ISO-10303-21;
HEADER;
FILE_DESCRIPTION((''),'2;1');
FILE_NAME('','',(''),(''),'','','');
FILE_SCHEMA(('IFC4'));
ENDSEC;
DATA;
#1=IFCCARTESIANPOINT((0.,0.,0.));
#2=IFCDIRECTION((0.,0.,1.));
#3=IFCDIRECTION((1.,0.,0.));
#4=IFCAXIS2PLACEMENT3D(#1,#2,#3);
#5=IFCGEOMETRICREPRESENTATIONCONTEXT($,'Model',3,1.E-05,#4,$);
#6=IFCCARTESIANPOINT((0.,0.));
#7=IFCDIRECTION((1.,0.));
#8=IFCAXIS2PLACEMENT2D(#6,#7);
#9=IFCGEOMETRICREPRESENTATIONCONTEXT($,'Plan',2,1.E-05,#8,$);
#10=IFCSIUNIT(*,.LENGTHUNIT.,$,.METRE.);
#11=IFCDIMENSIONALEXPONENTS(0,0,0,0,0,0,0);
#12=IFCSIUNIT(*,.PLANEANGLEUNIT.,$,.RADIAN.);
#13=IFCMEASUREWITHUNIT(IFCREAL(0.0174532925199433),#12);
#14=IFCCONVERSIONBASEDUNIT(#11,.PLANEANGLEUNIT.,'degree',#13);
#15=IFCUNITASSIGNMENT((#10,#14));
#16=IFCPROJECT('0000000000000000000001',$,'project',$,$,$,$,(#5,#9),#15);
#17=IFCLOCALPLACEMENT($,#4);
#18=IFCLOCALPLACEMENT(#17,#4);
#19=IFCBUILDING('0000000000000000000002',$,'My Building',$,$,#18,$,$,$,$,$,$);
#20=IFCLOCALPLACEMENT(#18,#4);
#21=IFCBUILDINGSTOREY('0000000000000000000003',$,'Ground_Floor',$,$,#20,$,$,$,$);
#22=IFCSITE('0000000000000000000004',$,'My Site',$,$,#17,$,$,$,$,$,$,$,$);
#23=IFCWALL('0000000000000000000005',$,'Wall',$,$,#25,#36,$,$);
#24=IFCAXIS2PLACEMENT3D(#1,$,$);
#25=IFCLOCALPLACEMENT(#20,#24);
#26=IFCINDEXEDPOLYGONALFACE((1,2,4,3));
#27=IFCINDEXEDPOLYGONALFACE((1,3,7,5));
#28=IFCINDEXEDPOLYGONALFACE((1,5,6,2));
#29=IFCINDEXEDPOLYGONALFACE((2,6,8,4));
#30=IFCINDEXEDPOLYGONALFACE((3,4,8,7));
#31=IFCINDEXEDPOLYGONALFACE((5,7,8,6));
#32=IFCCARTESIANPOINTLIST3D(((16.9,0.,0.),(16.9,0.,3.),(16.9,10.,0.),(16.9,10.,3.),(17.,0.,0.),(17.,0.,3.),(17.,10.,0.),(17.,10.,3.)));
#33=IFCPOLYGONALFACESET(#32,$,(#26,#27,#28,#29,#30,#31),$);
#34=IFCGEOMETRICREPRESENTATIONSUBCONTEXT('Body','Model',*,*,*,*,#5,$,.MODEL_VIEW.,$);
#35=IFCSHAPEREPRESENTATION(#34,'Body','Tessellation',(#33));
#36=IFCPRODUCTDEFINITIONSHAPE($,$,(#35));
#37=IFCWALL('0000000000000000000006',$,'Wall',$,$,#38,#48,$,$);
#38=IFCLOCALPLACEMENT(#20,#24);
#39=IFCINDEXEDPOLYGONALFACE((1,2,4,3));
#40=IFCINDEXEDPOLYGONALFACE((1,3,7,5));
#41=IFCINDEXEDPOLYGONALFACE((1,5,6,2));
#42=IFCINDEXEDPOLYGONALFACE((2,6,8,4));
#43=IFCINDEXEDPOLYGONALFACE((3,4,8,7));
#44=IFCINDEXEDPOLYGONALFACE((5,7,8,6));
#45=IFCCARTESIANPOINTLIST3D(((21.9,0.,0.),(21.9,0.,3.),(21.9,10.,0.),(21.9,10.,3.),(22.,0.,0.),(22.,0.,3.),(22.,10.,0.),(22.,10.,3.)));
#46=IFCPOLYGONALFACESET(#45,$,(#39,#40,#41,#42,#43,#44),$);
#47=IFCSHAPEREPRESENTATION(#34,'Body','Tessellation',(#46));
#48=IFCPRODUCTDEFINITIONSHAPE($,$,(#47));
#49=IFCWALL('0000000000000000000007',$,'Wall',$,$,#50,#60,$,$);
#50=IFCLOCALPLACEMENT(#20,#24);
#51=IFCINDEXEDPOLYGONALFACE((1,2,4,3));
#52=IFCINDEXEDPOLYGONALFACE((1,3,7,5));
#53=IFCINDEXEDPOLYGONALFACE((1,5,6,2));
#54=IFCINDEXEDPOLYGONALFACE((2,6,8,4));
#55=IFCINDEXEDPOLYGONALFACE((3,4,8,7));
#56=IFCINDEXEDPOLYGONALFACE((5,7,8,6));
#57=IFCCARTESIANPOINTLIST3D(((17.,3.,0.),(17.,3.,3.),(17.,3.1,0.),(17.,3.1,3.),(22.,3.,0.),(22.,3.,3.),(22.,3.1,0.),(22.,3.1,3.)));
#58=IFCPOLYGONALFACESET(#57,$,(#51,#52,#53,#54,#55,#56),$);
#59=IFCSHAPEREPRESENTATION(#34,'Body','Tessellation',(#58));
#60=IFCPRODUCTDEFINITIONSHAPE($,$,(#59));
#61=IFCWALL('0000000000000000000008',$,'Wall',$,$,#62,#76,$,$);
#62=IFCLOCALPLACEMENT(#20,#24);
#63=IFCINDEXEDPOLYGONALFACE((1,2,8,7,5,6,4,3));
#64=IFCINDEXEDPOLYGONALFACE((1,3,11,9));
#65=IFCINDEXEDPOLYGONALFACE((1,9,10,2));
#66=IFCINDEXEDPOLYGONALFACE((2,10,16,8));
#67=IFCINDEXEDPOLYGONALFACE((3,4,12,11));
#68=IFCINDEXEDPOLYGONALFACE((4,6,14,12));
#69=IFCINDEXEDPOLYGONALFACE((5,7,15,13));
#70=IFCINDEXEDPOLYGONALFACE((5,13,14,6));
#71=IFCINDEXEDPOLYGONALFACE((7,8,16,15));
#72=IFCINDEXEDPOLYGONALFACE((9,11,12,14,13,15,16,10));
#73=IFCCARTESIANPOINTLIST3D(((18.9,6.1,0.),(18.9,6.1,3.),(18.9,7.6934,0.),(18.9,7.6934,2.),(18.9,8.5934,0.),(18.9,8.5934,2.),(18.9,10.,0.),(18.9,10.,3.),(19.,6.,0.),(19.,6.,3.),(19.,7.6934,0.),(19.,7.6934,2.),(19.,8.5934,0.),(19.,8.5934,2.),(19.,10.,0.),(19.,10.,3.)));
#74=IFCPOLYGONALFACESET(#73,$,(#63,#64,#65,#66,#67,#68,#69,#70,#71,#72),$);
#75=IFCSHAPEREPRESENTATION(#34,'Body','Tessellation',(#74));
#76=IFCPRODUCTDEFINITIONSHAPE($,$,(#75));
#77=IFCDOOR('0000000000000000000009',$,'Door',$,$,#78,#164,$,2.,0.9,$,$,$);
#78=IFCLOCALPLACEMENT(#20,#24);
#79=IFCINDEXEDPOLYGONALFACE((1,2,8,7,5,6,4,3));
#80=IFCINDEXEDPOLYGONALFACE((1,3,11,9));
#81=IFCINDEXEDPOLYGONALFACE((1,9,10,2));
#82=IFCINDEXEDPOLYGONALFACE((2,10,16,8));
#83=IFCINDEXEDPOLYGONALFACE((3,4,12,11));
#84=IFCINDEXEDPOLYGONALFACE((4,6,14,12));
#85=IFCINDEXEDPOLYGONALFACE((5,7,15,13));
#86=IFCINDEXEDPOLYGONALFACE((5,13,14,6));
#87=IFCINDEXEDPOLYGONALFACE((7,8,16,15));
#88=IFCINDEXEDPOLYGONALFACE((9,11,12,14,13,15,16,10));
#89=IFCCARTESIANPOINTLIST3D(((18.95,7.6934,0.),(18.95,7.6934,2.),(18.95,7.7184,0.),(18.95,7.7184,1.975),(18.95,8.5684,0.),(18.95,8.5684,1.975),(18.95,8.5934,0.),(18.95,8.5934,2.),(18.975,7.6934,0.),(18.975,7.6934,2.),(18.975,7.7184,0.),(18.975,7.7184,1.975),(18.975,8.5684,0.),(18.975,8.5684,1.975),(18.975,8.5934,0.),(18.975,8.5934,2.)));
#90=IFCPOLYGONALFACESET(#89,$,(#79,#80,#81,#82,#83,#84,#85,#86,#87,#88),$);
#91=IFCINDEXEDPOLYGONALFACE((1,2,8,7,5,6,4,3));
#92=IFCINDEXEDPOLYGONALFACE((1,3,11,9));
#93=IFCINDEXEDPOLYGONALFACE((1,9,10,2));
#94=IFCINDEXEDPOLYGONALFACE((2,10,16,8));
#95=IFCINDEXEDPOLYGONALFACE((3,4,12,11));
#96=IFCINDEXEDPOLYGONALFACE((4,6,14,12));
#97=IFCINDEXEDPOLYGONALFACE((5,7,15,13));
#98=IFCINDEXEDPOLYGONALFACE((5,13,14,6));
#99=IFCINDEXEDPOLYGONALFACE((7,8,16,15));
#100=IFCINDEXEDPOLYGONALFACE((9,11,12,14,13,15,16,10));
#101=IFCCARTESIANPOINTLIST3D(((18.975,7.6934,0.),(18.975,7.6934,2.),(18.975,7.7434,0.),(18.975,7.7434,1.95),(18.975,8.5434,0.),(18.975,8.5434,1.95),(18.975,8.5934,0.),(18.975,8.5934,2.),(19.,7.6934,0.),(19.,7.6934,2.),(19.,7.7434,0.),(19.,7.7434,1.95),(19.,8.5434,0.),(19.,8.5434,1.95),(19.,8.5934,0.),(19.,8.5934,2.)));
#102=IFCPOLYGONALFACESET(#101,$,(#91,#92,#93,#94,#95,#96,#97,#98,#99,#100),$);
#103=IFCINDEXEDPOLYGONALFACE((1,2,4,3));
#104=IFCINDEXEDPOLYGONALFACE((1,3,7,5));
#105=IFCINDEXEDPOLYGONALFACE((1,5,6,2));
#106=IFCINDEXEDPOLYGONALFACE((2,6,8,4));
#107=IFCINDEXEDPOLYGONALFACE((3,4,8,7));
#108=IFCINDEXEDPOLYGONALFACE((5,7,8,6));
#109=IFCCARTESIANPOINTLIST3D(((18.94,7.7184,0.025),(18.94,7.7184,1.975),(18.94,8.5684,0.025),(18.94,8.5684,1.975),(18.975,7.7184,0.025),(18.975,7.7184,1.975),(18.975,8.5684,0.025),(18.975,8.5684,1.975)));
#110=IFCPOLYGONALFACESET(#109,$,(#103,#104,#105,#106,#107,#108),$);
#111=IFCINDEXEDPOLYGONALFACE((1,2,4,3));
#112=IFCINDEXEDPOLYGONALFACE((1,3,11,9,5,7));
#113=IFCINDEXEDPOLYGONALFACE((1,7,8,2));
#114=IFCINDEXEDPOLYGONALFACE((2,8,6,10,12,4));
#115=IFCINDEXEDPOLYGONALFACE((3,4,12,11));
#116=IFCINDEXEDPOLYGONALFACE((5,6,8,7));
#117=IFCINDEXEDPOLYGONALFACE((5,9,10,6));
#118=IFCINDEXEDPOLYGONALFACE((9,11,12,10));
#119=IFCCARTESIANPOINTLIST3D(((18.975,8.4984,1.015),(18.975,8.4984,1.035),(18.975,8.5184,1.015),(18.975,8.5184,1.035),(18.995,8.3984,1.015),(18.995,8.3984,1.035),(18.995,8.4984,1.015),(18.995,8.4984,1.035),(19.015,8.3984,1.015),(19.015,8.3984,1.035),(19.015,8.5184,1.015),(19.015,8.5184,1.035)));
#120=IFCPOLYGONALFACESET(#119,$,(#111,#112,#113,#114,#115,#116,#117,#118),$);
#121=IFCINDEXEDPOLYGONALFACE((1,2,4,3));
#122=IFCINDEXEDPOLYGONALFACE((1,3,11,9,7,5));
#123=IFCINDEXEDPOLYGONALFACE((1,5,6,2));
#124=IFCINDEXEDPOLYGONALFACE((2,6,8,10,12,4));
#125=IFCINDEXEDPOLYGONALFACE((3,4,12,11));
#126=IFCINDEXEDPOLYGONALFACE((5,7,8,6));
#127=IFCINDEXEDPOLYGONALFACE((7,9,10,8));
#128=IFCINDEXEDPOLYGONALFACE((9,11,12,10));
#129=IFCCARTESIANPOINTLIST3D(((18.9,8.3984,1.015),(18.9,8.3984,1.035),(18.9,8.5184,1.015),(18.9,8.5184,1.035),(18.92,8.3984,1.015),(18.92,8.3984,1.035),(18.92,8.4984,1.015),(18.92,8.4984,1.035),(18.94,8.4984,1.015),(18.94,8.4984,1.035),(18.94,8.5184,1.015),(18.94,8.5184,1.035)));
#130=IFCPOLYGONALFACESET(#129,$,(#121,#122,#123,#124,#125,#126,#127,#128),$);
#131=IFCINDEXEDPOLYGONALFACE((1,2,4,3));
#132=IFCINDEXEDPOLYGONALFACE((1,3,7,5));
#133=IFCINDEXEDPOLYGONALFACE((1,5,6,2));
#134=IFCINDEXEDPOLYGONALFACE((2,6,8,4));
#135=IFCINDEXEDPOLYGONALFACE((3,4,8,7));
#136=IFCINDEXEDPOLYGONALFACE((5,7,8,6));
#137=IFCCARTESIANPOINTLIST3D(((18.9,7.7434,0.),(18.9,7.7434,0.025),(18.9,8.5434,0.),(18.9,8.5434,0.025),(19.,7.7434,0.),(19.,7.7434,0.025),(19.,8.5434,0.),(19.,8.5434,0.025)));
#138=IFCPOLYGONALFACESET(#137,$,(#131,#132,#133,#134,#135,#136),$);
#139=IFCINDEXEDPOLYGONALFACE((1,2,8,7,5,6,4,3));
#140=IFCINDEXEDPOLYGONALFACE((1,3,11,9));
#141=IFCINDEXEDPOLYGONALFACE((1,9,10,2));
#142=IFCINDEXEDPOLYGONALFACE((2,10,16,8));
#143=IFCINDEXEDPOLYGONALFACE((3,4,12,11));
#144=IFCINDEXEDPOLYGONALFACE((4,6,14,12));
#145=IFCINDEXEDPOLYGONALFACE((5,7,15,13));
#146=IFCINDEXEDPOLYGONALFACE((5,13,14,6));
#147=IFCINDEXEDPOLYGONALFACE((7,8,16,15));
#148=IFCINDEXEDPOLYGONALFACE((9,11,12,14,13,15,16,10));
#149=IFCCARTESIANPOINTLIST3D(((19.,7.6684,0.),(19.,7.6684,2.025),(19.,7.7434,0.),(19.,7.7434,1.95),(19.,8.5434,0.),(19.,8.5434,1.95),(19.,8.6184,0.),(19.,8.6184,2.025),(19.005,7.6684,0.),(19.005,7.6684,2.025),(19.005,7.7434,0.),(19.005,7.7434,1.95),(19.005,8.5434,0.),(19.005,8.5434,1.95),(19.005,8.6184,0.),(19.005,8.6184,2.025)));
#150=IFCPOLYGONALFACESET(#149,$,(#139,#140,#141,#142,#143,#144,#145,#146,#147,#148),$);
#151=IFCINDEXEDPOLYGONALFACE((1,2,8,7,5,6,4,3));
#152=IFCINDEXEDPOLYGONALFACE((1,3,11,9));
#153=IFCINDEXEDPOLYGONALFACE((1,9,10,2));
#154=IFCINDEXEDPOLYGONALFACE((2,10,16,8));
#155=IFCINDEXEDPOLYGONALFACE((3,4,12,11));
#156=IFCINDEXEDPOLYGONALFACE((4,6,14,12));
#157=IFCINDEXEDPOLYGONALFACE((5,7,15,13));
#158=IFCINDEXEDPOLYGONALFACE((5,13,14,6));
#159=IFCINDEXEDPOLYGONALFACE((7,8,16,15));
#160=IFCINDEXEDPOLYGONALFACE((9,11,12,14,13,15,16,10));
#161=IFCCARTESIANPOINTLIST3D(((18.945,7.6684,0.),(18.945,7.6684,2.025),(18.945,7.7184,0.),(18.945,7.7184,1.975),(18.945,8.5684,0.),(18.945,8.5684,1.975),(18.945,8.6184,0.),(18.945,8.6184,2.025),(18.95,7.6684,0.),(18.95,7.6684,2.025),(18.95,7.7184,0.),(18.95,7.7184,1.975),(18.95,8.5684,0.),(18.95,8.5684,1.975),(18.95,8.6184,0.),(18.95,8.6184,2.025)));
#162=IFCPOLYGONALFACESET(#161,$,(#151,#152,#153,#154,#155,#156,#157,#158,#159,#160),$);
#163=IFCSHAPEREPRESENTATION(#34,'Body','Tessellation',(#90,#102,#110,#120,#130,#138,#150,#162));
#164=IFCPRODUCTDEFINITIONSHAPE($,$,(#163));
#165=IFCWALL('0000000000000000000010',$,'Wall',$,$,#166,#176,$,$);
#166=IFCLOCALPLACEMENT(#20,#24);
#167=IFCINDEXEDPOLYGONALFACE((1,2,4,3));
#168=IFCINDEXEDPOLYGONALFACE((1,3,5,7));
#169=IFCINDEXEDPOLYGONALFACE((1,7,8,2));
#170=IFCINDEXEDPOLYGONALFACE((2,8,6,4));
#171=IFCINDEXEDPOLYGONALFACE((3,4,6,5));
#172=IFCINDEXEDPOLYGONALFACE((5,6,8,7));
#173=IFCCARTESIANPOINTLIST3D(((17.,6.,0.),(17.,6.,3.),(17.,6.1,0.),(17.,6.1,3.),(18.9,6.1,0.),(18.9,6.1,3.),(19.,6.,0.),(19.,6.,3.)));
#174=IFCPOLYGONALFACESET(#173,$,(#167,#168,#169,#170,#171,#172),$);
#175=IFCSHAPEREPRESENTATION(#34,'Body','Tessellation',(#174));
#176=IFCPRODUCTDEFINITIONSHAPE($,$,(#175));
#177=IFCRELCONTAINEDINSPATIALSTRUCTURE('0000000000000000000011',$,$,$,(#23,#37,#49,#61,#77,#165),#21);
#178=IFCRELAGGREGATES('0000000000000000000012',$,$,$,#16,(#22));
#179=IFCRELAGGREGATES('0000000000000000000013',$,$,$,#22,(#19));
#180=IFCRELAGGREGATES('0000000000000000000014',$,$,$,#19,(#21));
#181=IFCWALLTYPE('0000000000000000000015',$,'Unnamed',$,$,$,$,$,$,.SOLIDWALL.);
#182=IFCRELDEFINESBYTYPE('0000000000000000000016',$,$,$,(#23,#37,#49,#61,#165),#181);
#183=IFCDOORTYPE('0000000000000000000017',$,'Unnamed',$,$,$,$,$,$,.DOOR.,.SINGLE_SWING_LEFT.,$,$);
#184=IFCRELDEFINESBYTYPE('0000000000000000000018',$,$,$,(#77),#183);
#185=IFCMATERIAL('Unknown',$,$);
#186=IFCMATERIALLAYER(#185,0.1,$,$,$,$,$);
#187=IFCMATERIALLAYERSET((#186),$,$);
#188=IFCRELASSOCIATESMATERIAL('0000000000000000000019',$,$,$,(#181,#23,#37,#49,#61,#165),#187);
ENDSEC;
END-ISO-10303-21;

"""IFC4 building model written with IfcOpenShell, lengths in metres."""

from ifc_helpers import new_model, entity, si_unit, converted_unit, frame, origin_with_axes, origin_2d_with_axis, place, context, subcontext, project, spatial, line, indexed_curve, outline, extrude, shape, source, transform, mapped, material, layer, layer_set, layer_usage, type_object, type_shapes, element, fill, save


model = new_model("IFC4")

# Units and contexts
model_context = context("Model", 3, precision=1e-05, world=origin_with_axes())
plan_context = context("Plan", 2, precision=1e-05, world=origin_2d_with_axis())
body_context_1 = subcontext(model_context, "Body", "Model", "MODEL_VIEW")
body_context_2 = subcontext(plan_context, "Body", "Plan", "PLAN_VIEW")
ifc_project = project(units=[si_unit("LENGTHUNIT", "METRE"), converted_unit("PLANEANGLEUNIT", "degree", entity("IfcReal", 0.0174532925199433), si_unit("PLANEANGLEUNIT", "RADIAN"), dimensions=[0, 0, 0, 0, 0, 0, 0])], contexts=[model_context, plan_context])

# Site, building, storey
site_placement = place(None, origin_with_axes())
site = spatial("IfcSite", under=ifc_project, at=site_placement, Name="My Site")
building_placement = place(site_placement, origin_with_axes())
building = spatial("IfcBuilding", under=site, at=building_placement, Name="My Building")
storey_placement = place(building_placement, origin_with_axes())
storey = spatial("IfcBuildingStorey", under=building, at=storey_placement, Name="Ground_Floor")

# Walls
ifc_material = material(Name="Unknown")
ifc_layer = layer(ifc_material, 0.1)
ifc_layer_set = layer_set([ifc_layer])
ifc_layer_usage_1 = layer_usage(ifc_layer_set, "AXIS2", "POSITIVE", 0.0)
wall_type = type_object("IfcWallType", Name="Unnamed", PredefinedType="SOLIDWALL", material=ifc_layer_set)
wall_1_placement = place(storey_placement, frame((17.0, 0.0, 0.0), z_axis=(0.0, 0.0, 1.0), x_axis=(0.0, 1.0, 0.0)))
element("IfcWall", 1, at=wall_1_placement, inside=storey, type_object=wall_type, material=ifc_layer_usage_1, Name="Wall", context=body_context_1, shape_type="SweptSolid", body=[
    extrude(outline(indexed_curve([(0.0, 0.0), (0.0, 0.1), (10.0, 0.1), (10.0, 0.0)], segments=[line(1, 2, 3, 4, 1)])), origin_with_axes(), (0.0, 0.0, 1.0), 3.0),
])
ifc_layer_usage_2 = layer_usage(ifc_layer_set, "AXIS2", "POSITIVE", 0.0)
wall_2_placement = place(storey_placement, frame((22.0, 0.0, 0.0), z_axis=(0.0, 0.0, 1.0), x_axis=(0.0, 1.0, 0.0)))
element("IfcWall", 2, at=wall_2_placement, inside=storey, type_object=wall_type, material=ifc_layer_usage_2, Name="Wall", context=body_context_1, shape_type="SweptSolid", body=[
    extrude(outline(indexed_curve([(0.0, 0.0), (0.0, 0.1), (10.0, 0.1), (10.0, 0.0)], segments=[line(1, 2, 3, 4, 1)])), origin_with_axes(), (0.0, 0.0, 1.0), 3.0),
])
ifc_layer_usage_3 = layer_usage(ifc_layer_set, "AXIS2", "POSITIVE", 0.0)
wall_3_placement = place(storey_placement, frame((17.0, 3.0, 0.0), z_axis=(0.0, 0.0, 1.0), x_axis=(1.0, 0.0, 0.0)))
element("IfcWall", 3, at=wall_3_placement, inside=storey, type_object=wall_type, material=ifc_layer_usage_3, Name="Wall", context=body_context_1, shape_type="SweptSolid", body=[
    extrude(outline(indexed_curve([(0.0, 0.0), (0.0, 0.1), (5.0, 0.1), (5.0, 0.0)], segments=[line(1, 2, 3, 4, 1)])), origin_with_axes(), (0.0, 0.0, 1.0), 3.0),
])

# Wall, opening, door
ifc_layer_usage_4 = layer_usage(ifc_layer_set, "AXIS2", "POSITIVE", 0.0)
wall_4_placement = place(storey_placement, frame((19.0, 6.0, 0.0), z_axis=(0.0, 0.0, 1.0), x_axis=(0.0, 1.0, 0.0)))
wall_4 = element("IfcWall", 4, at=wall_4_placement, inside=storey, type_object=wall_type, material=ifc_layer_usage_4, Name="Wall", context=body_context_1, shape_type="SweptSolid", body=[
    extrude(outline(indexed_curve([(0.0, 0.0), (0.1, 0.1), (4.0, 0.1), (4.0, 0.0)], segments=[line(1, 2, 3, 4, 1)])), origin_with_axes(), (0.0, 0.0, 1.0), 3.0),
])
shared_shape_1 = source(origin_with_axes(), body_context_1, "Body", "SweptSolid", [
    extrude(outline(indexed_curve([(0.0, 0.0), (0.9, 0.0), (0.9, 2.0), (0.0, 2.0)], segments=[line(1, 2, 3, 4, 1)])), frame((0.0, -0.6, 0.0), z_axis=(0.0, -1.0, 0.0), x_axis=(1.0, 0.0, 0.0)), (0.0, 0.0, -1.0), 1.2),
])
opening_1_placement = place(wall_4_placement, frame((1.6934, 0.0, 0.0), z_axis=(0.0, 0.0, 1.0), x_axis=(1.0, 0.0, 0.0)))
opening_1 = element("IfcOpeningElement", 5, at=opening_1_placement, cuts=wall_4, PredefinedType="OPENING", context=body_context_1, shape_type="MappedRepresentation", body=[
    mapped(shared_shape_1, transform((0.0, 0.0, 0.0), x_axis=(1.0, 0.0, 0.0), y_axis=(0.0, 1.0, 0.0), z_axis=(0.0, 0.0, 1.0), scale=1.0)),
])
door_type_1 = type_object("IfcDoorType", Name="Unnamed", OperationType="SINGLE_SWING_LEFT", PredefinedType="DOOR")
shared_shape_2 = source(origin_with_axes(), body_context_1, "Body", "SweptSolid", [
    extrude(outline(indexed_curve([(0.0, 0.0), (0.0, 2.0), (0.9, 2.0), (0.9, 0.0), (0.875, 0.0), (0.875, 1.975), (0.025, 1.975), (0.025, 0.0)], segments=[line(1, 2, 3, 4, 5, 6, 7, 8, 1)])), frame((0.0, 0.025, 0.0), z_axis=(0.0, -1.0, 0.0), x_axis=(1.0, 0.0, 0.0)), (0.0, 0.0, -1.0), 0.025),
    extrude(outline(indexed_curve([(0.0, 0.0), (0.0, 2.0), (0.9, 2.0), (0.9, 0.0), (0.85, 0.0), (0.85, 1.95), (0.05, 1.95), (0.05, 0.0)], segments=[line(1, 2, 3, 4, 5, 6, 7, 8, 1)])), frame((0.0, 0.0, 0.0), z_axis=(0.0, -1.0, 0.0), x_axis=(1.0, 0.0, 0.0)), (0.0, 0.0, -1.0), 0.025),
    extrude(outline(indexed_curve([(0.0, 0.0), (0.85, 0.0), (0.85, 0.035), (0.0, 0.035)], segments=[line(1, 2, 3, 4, 1)])), frame((0.025, 0.025, 0.025), z_axis=(0.0, 0.0, 1.0), x_axis=(1.0, 0.0, 0.0)), (0.0, 0.0, 1.0), 1.95),
    extrude(outline(indexed_curve([(0.0, 0.0), (0.0, -0.04), (-0.12, -0.04), (-0.12, -0.02), (-0.02, -0.02), (-0.02, 0.0)], segments=[line(1, 2, 3, 4, 5, 6, 1)])), frame((0.825, 0.025, 1.015), z_axis=(0.0, 0.0, 1.0), x_axis=(1.0, 0.0, 0.0)), (0.0, 0.0, 1.0), 0.02),
    extrude(outline(indexed_curve([(0.0, 0.0), (0.0, 0.04), (-0.12, 0.04), (-0.12, 0.02), (-0.02, 0.02), (-0.02, 0.0)], segments=[line(1, 2, 3, 4, 5, 6, 1)])), frame((0.825, 0.06, 1.015), z_axis=(0.0, 0.0, 1.0), x_axis=(1.0, 0.0, 0.0)), (0.0, 0.0, 1.0), 0.02),
    extrude(outline(indexed_curve([(0.0, 0.0), (0.8, 0.0), (0.8, 0.1), (0.0, 0.1)], segments=[line(1, 2, 3, 4, 1)])), frame((0.05, 0.0, 0.0), z_axis=(0.0, 0.0, 1.0), x_axis=(1.0, 0.0, 0.0)), (0.0, 0.0, 1.0), 0.025),
    extrude(outline(indexed_curve([(0.0, 0.0), (0.0, 2.025), (0.95, 2.025), (0.95, 0.0), (0.875, 0.0), (0.875, 1.95), (0.075, 1.95), (0.075, 0.0)], segments=[line(1, 2, 3, 4, 5, 6, 7, 8, 1)])), frame((-0.025, -0.005, 0.0), z_axis=(0.0, -1.0, 0.0), x_axis=(1.0, 0.0, 0.0)), (0.0, 0.0, -1.0), 0.005),
    extrude(outline(indexed_curve([(0.0, 0.0), (0.0, 2.025), (0.95, 2.025), (0.95, 0.0), (0.9, 0.0), (0.9, 1.975), (0.05, 1.975), (0.05, 0.0)], segments=[line(1, 2, 3, 4, 5, 6, 7, 8, 1)])), frame((-0.025, 0.05, 0.0), z_axis=(0.0, -1.0, 0.0), x_axis=(1.0, 0.0, 0.0)), (0.0, 0.0, -1.0), 0.005),
])
shared_shape_3 = source(origin_with_axes(), body_context_2, "Body", "Curve2D", [
    entity("IfcIndexedPolyCurve", entity("IfcCartesianPointList2D", [[0.0, 0.0], [0.0, 0.05], [0.025, 0.05], [0.025, 0.025], [0.05, 0.025], [0.05, 0.0]]), [entity("IfcLineIndex", [1, 2, 3, 4, 5, 6, 1])]),
    entity("IfcIndexedPolyCurve", entity("IfcCartesianPointList2D", [[0.9, 0.0], [0.9, 0.05], [0.875, 0.05], [0.875, 0.025], [0.85, 0.025], [0.85, 0.0]]), [entity("IfcLineIndex", [1, 2, 3, 4, 5, 6, 1])]),
    entity("IfcTrimmedCurve", entity("IfcEllipse", entity("IfcAxis2Placement2D", entity("IfcCartesianPoint", [0.06, 0.05]), entity("IfcDirection", [1.0, 0.0])), 0.815, 0.85), [entity("IfcCartesianPoint", [0.875, 0.05])], [entity("IfcCartesianPoint", [0.06, 0.9])], True, "CARTESIAN"),
    entity("IfcIndexedPolyCurve", entity("IfcCartesianPointList2D", [[0.025, 0.05], [0.06, 0.05], [0.06, 0.9], [0.025, 0.9]]), [entity("IfcLineIndex", [1, 2, 3, 4, 1])]),
])
type_shapes(door_type_1, [shared_shape_2, shared_shape_3])
door_1_placement = place(opening_1_placement, frame((0.0, 0.0, 0.0), z_axis=(0.0, 0.0, 1.0), x_axis=(1.0, 0.0, 0.0)))
door_1 = element("IfcDoor", 6, at=door_1_placement, inside=storey, type_object=door_type_1, Name="Door", OverallHeight=2.0, OverallWidth=0.9, shapes=[
    shape(body_context_1, "Body", "MappedRepresentation", [mapped(shared_shape_2, transform((0.0, 0.0, 0.0), x_axis=(1.0, 0.0, 0.0), y_axis=(0.0, 1.0, 0.0), z_axis=(0.0, 0.0, 1.0), scale=1.0))]),
    shape(body_context_2, "Body", "MappedRepresentation", [mapped(shared_shape_3, transform((0.0, 0.0, 0.0), x_axis=(1.0, 0.0, 0.0), y_axis=(0.0, 1.0, 0.0), z_axis=(0.0, 0.0, 1.0), scale=1.0))]),
])
fill(opening_1, door_1)

# Wall
ifc_layer_usage_5 = layer_usage(ifc_layer_set, "AXIS2", "POSITIVE", 0.0)
wall_5_placement = place(storey_placement, frame((17.0, 6.0, 0.0), z_axis=(0.0, 0.0, 1.0), x_axis=(1.0, 0.0, 0.0)))
element("IfcWall", 7, at=wall_5_placement, inside=storey, type_object=wall_type, material=ifc_layer_usage_5, Name="Wall", context=body_context_1, shape_type="SweptSolid", body=[
    extrude(outline(indexed_curve([(0.0, 0.0), (0.0, 0.1), (1.9, 0.1), (2.0, 0.0)], segments=[line(1, 2, 3, 4, 1)])), origin_with_axes(), (0.0, 0.0, 1.0), 3.0),
])

save(model, "model.ifc")
